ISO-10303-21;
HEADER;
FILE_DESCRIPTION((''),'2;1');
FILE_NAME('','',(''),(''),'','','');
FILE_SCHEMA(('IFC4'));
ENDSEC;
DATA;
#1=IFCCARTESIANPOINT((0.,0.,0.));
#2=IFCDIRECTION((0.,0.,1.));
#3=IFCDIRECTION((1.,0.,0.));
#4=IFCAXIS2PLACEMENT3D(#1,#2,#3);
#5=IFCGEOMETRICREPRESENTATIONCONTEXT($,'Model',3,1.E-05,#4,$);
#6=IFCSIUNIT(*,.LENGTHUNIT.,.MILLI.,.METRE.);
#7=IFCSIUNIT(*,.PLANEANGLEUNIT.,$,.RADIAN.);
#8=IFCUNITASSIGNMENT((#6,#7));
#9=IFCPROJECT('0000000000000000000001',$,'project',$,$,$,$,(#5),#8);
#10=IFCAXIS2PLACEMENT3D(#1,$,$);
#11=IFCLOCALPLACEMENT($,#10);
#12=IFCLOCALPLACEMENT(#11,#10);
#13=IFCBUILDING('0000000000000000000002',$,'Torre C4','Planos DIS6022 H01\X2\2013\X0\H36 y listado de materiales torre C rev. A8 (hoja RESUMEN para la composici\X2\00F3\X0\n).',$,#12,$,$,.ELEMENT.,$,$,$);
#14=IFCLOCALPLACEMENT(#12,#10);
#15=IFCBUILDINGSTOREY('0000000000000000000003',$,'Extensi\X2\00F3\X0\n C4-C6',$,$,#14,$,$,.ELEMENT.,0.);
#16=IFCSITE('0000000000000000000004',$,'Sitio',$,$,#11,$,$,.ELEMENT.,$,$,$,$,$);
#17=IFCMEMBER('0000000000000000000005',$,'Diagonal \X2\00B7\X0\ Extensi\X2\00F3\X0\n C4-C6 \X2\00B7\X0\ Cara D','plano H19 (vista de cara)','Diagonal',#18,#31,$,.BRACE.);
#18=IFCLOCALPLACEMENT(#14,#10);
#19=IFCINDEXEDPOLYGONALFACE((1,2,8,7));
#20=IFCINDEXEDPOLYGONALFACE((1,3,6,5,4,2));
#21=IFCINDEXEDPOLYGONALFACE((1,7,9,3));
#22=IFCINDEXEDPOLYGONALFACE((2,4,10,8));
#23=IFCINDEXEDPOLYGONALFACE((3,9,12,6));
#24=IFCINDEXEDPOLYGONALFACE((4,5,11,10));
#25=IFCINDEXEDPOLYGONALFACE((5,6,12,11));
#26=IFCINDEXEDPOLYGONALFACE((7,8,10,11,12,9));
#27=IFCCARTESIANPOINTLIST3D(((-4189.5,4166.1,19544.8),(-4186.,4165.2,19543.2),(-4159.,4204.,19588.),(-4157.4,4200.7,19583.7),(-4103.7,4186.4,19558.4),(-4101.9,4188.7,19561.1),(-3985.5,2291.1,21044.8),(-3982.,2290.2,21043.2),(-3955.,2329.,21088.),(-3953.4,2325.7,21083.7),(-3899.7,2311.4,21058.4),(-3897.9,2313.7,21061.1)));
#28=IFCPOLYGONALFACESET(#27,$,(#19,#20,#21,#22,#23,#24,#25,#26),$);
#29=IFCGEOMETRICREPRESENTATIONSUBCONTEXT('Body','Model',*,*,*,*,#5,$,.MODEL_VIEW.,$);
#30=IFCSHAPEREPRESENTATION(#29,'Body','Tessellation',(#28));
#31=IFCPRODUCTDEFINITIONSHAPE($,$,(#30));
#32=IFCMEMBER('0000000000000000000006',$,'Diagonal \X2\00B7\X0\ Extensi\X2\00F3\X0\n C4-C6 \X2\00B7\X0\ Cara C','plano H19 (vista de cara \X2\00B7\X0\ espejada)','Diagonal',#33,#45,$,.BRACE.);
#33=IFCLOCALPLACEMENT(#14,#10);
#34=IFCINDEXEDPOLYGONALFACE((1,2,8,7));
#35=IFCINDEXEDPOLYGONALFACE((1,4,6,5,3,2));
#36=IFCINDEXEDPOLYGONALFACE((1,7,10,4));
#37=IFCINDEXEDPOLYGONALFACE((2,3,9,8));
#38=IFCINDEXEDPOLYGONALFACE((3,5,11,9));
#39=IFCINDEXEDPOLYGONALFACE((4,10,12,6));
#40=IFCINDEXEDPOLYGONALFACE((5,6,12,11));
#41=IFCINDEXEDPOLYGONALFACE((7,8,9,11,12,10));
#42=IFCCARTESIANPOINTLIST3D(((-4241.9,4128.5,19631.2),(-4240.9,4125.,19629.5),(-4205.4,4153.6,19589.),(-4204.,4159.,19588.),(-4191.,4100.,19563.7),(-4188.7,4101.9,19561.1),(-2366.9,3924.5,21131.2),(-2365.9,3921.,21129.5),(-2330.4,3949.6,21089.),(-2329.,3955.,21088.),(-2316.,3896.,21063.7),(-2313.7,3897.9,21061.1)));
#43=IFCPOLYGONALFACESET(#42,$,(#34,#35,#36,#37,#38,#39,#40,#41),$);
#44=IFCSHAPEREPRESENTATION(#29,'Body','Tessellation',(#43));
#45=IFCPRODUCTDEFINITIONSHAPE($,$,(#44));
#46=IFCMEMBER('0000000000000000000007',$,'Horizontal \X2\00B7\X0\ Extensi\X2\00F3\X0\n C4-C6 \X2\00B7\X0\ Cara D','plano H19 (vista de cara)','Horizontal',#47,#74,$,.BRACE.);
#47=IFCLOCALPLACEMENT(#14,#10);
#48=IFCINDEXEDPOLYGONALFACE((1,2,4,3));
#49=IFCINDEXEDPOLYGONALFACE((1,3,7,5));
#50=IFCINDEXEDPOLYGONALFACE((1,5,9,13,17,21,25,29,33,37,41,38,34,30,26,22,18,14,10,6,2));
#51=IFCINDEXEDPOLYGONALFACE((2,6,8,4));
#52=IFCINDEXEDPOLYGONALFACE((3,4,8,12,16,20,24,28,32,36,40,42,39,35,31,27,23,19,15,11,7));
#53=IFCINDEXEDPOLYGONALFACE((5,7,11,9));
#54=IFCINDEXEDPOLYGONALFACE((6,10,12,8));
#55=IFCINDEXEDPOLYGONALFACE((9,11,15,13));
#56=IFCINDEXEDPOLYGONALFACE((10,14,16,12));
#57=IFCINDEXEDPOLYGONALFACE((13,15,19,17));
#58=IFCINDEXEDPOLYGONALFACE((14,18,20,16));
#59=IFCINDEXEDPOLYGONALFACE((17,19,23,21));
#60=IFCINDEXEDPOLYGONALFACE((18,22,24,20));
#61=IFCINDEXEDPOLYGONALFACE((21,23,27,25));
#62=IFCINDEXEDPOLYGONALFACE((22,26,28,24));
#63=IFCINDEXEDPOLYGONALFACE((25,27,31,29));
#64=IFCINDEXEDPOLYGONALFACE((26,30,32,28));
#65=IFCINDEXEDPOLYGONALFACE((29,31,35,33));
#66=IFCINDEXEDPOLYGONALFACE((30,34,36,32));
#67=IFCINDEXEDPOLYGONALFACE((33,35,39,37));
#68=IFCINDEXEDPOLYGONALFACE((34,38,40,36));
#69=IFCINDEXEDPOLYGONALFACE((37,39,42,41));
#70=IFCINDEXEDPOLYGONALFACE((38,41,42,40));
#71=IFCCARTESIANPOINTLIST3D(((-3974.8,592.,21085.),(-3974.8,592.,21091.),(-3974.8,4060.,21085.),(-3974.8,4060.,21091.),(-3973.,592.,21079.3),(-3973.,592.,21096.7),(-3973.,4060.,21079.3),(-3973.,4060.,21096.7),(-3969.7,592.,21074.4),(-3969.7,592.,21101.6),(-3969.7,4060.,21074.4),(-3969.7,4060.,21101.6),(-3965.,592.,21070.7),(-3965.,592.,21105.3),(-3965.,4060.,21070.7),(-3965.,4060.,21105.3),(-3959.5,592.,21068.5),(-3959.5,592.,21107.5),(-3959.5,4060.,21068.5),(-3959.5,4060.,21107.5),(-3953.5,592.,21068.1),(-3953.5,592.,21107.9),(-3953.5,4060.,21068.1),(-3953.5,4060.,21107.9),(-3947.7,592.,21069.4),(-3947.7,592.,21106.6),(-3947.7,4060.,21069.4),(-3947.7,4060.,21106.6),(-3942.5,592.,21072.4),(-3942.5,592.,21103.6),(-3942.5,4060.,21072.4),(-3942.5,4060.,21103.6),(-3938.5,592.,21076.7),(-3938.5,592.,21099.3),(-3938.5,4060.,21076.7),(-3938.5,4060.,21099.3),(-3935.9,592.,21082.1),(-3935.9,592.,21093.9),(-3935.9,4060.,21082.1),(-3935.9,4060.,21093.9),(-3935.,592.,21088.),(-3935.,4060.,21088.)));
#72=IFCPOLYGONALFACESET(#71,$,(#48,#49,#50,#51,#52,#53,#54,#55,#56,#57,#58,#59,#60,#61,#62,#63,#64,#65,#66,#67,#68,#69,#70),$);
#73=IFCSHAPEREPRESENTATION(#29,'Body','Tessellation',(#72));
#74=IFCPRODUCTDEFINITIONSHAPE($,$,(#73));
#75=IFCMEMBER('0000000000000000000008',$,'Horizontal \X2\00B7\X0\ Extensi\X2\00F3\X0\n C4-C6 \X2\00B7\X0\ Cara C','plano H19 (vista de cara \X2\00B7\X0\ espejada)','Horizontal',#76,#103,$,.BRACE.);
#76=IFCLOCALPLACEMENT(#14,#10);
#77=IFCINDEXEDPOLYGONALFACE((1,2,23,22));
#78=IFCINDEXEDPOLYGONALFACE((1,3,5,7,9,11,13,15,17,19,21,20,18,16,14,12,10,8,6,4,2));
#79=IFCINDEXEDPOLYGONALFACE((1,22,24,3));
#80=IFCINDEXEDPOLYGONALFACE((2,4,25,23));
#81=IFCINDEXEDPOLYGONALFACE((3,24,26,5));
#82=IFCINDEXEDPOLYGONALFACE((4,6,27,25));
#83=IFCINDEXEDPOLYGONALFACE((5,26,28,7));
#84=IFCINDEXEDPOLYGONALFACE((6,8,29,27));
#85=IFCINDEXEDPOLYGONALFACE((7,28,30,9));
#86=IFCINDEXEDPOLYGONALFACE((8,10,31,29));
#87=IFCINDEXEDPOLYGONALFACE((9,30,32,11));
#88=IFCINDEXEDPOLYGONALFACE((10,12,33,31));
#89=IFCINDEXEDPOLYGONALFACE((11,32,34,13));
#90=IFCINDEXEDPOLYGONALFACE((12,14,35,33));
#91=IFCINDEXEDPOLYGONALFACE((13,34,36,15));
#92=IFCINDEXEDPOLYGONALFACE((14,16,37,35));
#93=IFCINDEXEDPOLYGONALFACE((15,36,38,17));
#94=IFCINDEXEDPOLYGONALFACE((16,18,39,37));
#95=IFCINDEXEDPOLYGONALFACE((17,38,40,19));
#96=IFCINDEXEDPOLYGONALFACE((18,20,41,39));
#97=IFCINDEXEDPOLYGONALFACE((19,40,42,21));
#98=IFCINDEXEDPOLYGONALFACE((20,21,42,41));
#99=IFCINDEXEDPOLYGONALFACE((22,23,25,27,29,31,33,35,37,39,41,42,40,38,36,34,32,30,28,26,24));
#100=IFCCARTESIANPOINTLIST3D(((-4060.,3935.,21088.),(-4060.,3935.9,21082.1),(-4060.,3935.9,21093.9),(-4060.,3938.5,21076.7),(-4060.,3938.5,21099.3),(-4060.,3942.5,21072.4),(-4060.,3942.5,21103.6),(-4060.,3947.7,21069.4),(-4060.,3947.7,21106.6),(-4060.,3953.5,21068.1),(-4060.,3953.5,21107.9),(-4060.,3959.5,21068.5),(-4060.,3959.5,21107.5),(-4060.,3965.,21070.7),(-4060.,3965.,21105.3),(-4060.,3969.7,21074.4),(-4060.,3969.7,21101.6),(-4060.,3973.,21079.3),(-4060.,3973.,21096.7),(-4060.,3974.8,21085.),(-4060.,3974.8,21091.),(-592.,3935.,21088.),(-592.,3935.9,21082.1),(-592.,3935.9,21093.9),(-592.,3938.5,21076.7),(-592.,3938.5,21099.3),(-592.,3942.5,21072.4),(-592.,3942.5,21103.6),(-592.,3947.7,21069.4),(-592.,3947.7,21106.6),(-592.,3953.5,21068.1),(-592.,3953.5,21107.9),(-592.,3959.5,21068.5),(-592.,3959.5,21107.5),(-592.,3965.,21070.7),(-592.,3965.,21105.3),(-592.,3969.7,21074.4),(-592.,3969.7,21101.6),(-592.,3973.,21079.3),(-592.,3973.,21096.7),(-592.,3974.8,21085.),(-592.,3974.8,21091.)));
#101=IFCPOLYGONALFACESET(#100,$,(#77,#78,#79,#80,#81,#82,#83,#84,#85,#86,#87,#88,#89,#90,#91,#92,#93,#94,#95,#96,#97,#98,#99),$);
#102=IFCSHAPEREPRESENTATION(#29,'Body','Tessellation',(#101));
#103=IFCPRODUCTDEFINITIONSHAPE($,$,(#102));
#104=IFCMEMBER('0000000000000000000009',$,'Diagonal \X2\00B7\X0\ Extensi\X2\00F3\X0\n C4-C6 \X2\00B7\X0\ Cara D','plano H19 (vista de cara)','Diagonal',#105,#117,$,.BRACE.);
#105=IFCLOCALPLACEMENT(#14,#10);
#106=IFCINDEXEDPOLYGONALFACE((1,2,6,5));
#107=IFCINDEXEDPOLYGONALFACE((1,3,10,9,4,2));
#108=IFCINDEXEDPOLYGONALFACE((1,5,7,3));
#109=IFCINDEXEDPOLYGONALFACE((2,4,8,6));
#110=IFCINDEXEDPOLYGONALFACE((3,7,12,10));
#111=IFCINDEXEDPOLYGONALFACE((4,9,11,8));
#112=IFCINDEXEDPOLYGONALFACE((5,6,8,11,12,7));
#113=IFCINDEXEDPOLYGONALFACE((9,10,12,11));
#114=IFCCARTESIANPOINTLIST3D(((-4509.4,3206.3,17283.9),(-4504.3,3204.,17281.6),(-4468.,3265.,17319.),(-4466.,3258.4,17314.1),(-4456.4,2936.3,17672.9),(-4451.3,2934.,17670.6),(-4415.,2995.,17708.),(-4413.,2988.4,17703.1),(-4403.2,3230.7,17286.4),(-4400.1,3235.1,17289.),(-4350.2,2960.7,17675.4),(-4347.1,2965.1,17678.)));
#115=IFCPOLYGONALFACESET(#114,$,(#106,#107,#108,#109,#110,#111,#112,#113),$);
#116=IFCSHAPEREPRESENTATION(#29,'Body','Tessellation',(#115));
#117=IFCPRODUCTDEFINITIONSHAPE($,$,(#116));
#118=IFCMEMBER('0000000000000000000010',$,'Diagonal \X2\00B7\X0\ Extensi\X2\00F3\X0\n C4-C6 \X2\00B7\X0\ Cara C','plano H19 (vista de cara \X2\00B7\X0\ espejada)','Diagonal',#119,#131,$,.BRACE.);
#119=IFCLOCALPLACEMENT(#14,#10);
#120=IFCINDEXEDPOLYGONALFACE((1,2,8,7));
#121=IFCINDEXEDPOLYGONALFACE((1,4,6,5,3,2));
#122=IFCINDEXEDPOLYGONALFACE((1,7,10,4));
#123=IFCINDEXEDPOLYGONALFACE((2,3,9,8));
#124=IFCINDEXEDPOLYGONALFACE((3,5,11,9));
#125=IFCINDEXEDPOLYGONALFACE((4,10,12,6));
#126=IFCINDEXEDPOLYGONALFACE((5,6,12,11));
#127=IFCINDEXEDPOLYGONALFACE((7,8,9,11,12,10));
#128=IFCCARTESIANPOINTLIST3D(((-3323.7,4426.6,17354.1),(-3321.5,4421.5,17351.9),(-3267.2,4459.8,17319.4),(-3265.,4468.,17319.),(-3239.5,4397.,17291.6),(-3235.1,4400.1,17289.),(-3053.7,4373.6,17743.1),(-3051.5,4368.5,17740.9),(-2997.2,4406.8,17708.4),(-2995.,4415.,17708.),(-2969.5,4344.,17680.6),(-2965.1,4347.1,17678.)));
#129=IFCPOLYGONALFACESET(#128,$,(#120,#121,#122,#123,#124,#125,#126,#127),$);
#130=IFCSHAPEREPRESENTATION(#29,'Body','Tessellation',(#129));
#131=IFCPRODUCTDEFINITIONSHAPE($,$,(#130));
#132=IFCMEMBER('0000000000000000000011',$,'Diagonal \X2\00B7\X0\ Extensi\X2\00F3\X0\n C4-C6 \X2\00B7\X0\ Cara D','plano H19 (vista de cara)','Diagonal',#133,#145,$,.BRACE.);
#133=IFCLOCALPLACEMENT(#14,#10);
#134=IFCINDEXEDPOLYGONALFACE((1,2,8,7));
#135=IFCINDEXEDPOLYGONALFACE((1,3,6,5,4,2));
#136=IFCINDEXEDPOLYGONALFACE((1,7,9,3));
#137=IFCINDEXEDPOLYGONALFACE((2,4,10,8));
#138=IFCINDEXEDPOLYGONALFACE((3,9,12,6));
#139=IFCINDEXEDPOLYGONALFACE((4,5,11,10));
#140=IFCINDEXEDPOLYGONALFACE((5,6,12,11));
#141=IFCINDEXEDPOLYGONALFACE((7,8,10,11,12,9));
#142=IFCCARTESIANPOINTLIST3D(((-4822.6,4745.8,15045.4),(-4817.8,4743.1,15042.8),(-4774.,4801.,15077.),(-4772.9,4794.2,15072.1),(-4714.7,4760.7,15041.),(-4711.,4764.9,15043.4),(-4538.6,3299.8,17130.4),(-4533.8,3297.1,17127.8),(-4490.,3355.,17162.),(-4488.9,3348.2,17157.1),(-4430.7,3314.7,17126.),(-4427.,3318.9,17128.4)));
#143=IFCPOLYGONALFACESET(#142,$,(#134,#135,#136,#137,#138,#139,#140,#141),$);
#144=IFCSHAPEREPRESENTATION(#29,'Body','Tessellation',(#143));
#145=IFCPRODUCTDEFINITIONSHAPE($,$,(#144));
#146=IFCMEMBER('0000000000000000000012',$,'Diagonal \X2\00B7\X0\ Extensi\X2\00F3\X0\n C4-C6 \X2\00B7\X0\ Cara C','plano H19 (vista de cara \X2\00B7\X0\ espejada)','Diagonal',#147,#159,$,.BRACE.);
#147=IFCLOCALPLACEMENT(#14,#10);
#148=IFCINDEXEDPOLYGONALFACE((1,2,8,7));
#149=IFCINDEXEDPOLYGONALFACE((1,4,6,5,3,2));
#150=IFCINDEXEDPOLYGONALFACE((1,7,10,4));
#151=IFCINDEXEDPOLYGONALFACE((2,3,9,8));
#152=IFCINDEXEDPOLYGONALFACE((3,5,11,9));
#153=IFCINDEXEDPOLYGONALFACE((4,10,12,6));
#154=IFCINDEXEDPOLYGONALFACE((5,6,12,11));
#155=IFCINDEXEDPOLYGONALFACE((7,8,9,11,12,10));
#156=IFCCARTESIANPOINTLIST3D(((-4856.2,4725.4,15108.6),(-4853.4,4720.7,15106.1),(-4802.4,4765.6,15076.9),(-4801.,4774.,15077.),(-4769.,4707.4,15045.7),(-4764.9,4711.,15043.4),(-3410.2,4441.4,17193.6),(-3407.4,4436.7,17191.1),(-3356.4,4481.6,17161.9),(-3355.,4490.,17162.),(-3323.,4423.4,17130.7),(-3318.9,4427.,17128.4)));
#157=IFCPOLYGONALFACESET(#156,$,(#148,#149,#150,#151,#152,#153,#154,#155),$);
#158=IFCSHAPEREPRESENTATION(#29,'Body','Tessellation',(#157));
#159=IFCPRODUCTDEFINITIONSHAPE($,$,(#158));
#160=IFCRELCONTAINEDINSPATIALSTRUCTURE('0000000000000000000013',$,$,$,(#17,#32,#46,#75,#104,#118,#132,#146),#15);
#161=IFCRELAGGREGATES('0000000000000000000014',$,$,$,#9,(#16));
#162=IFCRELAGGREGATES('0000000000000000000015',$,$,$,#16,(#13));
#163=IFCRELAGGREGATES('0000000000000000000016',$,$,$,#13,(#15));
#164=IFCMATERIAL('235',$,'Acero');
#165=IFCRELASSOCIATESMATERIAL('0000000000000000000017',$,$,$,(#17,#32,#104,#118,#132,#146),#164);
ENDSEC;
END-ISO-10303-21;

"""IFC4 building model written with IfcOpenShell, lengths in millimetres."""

from ifc_helpers import new_model, si_unit, frame, frame_2d, origin, origin_with_axes, place, context, subcontext, project, spatial, circle, l_section, extrude, material, element, save


model = new_model("IFC4")

# Units and contexts
model_context = context("Model", 3, precision=1e-05, world=origin_with_axes())
body_context = subcontext(model_context, "Body", "Model", "MODEL_VIEW")
ifc_project = project(units=[si_unit("LENGTHUNIT", "METRE", prefix="MILLI"), si_unit("PLANEANGLEUNIT", "RADIAN")], contexts=[model_context])

# Site, building, storey
site_placement = place(None, origin())
site = spatial("IfcSite", under=ifc_project, at=site_placement, Name="Sitio", CompositionType="ELEMENT")
building_placement = place(site_placement, origin())
building = spatial("IfcBuilding", under=site, at=building_placement, Name="Torre C4", Description="Planos DIS6022 H01–H36 y listado de materiales torre C rev. A8 (hoja RESUMEN para la composición).", CompositionType="ELEMENT")
storey_placement = place(building_placement, origin())
storey = spatial("IfcBuildingStorey", under=building, at=storey_placement, Name="Extensión C4-C6", CompositionType="ELEMENT", Elevation=0.0)

# Members
ifc_material = material(Name="235", Category="Acero")
for number, where, z_axis, x_axis, name, description in (
    (1, (-3955.0, 2329.0, 21088.0), (-0.084654, 0.778066, -0.622453), (0.879209, -0.235619, -0.414097), "Diagonal · Extensión C4-C6 · Cara D", "plano H19 (vista de cara)"),
    (2, (-2329.0, 3955.0, 21088.0), (-0.778066, 0.084654, -0.622453), (0.235619, -0.879209, -0.414097), "Diagonal · Extensión C4-C6 · Cara C", "plano H19 (vista de cara · espejada)"),
):
    element("IfcMember", number, at=place(storey_placement, frame(where, z_axis=z_axis, x_axis=x_axis)), inside=storey, material=ifc_material, Name=name, Description=description, ObjectType="Diagonal", PredefinedType="BRACE", context=body_context, shape_type="SweptSolid", body=[
        extrude(l_section(Depth=65.0, Width=65.0, Thickness=4.0, at=frame_2d((32.5, 32.5))), None, (0.0, 0.0, 1.0), 2409.8),
    ])
for number, where, z_axis, x_axis, name, description in (
    (3, (-3955.0, 592.0, 21088.0), (0.0, 1.0, 0.0), (1.0, 0.0, 0.0), "Horizontal · Extensión C4-C6 · Cara D", "plano H19 (vista de cara)"),
    (4, (-592.0, 3955.0, 21088.0), (-1.0, 0.0, 0.0), (0.0, -1.0, 0.0), "Horizontal · Extensión C4-C6 · Cara C", "plano H19 (vista de cara · espejada)"),
):
    element("IfcMember", number, at=place(storey_placement, frame(where, z_axis=z_axis, x_axis=x_axis)), inside=storey, Name=name, Description=description, ObjectType="Horizontal", PredefinedType="BRACE", context=body_context, shape_type="SweptSolid", body=[
        extrude(circle(Radius=20.0), None, (0.0, 0.0, 1.0), 3468.0),
    ])
for number, where, z_axis, x_axis, name, description in (
    (5, (-4415.0, 2995.0, 17708.0), (-0.111233, 0.566659, -0.816409), (0.848414, -0.37365, -0.37494), "Diagonal · Extensión C4-C6 · Cara D", "plano H19 (vista de cara)"),
    (6, (-2995.0, 4415.0, 17708.0), (-0.566659, 0.111233, -0.816409), (0.37365, -0.848414, -0.37494), "Diagonal · Extensión C4-C6 · Cara C", "plano H19 (vista de cara · espejada)"),
):
    element("IfcMember", number, at=place(storey_placement, frame(where, z_axis=z_axis, x_axis=x_axis)), inside=storey, material=ifc_material, Name=name, Description=description, ObjectType="Diagonal", PredefinedType="BRACE", context=body_context, shape_type="SweptSolid", body=[
        extrude(l_section(Depth=80.0, Width=80.0, Thickness=6.0, at=frame_2d((40.0, 40.0))), None, (0.0, 0.0, 1.0), 476.5),
    ])
for number, where, z_axis, x_axis, name, description in (
    (7, (-4490.0, 3355.0, 17162.0), (-0.111233, 0.56635, -0.816624), (0.786928, -0.451653, -0.420421), "Diagonal · Extensión C4-C6 · Cara D", "plano H19 (vista de cara)"),
    (8, (-3355.0, 4490.0, 17162.0), (-0.56635, 0.111233, -0.816624), (0.451653, -0.786928, -0.420421), "Diagonal · Extensión C4-C6 · Cara C", "plano H19 (vista de cara · espejada)"),
):
    element("IfcMember", number, at=place(storey_placement, frame(where, z_axis=z_axis, x_axis=x_axis)), inside=storey, material=ifc_material, Name=name, Description=description, ObjectType="Diagonal", PredefinedType="BRACE", context=body_context, shape_type="SweptSolid", body=[
        extrude(l_section(Depth=80.0, Width=80.0, Thickness=6.0, at=frame_2d((40.0, 40.0))), None, (0.0, 0.0, 1.0), 2553.2),
    ])

save(model, "model.ifc")
